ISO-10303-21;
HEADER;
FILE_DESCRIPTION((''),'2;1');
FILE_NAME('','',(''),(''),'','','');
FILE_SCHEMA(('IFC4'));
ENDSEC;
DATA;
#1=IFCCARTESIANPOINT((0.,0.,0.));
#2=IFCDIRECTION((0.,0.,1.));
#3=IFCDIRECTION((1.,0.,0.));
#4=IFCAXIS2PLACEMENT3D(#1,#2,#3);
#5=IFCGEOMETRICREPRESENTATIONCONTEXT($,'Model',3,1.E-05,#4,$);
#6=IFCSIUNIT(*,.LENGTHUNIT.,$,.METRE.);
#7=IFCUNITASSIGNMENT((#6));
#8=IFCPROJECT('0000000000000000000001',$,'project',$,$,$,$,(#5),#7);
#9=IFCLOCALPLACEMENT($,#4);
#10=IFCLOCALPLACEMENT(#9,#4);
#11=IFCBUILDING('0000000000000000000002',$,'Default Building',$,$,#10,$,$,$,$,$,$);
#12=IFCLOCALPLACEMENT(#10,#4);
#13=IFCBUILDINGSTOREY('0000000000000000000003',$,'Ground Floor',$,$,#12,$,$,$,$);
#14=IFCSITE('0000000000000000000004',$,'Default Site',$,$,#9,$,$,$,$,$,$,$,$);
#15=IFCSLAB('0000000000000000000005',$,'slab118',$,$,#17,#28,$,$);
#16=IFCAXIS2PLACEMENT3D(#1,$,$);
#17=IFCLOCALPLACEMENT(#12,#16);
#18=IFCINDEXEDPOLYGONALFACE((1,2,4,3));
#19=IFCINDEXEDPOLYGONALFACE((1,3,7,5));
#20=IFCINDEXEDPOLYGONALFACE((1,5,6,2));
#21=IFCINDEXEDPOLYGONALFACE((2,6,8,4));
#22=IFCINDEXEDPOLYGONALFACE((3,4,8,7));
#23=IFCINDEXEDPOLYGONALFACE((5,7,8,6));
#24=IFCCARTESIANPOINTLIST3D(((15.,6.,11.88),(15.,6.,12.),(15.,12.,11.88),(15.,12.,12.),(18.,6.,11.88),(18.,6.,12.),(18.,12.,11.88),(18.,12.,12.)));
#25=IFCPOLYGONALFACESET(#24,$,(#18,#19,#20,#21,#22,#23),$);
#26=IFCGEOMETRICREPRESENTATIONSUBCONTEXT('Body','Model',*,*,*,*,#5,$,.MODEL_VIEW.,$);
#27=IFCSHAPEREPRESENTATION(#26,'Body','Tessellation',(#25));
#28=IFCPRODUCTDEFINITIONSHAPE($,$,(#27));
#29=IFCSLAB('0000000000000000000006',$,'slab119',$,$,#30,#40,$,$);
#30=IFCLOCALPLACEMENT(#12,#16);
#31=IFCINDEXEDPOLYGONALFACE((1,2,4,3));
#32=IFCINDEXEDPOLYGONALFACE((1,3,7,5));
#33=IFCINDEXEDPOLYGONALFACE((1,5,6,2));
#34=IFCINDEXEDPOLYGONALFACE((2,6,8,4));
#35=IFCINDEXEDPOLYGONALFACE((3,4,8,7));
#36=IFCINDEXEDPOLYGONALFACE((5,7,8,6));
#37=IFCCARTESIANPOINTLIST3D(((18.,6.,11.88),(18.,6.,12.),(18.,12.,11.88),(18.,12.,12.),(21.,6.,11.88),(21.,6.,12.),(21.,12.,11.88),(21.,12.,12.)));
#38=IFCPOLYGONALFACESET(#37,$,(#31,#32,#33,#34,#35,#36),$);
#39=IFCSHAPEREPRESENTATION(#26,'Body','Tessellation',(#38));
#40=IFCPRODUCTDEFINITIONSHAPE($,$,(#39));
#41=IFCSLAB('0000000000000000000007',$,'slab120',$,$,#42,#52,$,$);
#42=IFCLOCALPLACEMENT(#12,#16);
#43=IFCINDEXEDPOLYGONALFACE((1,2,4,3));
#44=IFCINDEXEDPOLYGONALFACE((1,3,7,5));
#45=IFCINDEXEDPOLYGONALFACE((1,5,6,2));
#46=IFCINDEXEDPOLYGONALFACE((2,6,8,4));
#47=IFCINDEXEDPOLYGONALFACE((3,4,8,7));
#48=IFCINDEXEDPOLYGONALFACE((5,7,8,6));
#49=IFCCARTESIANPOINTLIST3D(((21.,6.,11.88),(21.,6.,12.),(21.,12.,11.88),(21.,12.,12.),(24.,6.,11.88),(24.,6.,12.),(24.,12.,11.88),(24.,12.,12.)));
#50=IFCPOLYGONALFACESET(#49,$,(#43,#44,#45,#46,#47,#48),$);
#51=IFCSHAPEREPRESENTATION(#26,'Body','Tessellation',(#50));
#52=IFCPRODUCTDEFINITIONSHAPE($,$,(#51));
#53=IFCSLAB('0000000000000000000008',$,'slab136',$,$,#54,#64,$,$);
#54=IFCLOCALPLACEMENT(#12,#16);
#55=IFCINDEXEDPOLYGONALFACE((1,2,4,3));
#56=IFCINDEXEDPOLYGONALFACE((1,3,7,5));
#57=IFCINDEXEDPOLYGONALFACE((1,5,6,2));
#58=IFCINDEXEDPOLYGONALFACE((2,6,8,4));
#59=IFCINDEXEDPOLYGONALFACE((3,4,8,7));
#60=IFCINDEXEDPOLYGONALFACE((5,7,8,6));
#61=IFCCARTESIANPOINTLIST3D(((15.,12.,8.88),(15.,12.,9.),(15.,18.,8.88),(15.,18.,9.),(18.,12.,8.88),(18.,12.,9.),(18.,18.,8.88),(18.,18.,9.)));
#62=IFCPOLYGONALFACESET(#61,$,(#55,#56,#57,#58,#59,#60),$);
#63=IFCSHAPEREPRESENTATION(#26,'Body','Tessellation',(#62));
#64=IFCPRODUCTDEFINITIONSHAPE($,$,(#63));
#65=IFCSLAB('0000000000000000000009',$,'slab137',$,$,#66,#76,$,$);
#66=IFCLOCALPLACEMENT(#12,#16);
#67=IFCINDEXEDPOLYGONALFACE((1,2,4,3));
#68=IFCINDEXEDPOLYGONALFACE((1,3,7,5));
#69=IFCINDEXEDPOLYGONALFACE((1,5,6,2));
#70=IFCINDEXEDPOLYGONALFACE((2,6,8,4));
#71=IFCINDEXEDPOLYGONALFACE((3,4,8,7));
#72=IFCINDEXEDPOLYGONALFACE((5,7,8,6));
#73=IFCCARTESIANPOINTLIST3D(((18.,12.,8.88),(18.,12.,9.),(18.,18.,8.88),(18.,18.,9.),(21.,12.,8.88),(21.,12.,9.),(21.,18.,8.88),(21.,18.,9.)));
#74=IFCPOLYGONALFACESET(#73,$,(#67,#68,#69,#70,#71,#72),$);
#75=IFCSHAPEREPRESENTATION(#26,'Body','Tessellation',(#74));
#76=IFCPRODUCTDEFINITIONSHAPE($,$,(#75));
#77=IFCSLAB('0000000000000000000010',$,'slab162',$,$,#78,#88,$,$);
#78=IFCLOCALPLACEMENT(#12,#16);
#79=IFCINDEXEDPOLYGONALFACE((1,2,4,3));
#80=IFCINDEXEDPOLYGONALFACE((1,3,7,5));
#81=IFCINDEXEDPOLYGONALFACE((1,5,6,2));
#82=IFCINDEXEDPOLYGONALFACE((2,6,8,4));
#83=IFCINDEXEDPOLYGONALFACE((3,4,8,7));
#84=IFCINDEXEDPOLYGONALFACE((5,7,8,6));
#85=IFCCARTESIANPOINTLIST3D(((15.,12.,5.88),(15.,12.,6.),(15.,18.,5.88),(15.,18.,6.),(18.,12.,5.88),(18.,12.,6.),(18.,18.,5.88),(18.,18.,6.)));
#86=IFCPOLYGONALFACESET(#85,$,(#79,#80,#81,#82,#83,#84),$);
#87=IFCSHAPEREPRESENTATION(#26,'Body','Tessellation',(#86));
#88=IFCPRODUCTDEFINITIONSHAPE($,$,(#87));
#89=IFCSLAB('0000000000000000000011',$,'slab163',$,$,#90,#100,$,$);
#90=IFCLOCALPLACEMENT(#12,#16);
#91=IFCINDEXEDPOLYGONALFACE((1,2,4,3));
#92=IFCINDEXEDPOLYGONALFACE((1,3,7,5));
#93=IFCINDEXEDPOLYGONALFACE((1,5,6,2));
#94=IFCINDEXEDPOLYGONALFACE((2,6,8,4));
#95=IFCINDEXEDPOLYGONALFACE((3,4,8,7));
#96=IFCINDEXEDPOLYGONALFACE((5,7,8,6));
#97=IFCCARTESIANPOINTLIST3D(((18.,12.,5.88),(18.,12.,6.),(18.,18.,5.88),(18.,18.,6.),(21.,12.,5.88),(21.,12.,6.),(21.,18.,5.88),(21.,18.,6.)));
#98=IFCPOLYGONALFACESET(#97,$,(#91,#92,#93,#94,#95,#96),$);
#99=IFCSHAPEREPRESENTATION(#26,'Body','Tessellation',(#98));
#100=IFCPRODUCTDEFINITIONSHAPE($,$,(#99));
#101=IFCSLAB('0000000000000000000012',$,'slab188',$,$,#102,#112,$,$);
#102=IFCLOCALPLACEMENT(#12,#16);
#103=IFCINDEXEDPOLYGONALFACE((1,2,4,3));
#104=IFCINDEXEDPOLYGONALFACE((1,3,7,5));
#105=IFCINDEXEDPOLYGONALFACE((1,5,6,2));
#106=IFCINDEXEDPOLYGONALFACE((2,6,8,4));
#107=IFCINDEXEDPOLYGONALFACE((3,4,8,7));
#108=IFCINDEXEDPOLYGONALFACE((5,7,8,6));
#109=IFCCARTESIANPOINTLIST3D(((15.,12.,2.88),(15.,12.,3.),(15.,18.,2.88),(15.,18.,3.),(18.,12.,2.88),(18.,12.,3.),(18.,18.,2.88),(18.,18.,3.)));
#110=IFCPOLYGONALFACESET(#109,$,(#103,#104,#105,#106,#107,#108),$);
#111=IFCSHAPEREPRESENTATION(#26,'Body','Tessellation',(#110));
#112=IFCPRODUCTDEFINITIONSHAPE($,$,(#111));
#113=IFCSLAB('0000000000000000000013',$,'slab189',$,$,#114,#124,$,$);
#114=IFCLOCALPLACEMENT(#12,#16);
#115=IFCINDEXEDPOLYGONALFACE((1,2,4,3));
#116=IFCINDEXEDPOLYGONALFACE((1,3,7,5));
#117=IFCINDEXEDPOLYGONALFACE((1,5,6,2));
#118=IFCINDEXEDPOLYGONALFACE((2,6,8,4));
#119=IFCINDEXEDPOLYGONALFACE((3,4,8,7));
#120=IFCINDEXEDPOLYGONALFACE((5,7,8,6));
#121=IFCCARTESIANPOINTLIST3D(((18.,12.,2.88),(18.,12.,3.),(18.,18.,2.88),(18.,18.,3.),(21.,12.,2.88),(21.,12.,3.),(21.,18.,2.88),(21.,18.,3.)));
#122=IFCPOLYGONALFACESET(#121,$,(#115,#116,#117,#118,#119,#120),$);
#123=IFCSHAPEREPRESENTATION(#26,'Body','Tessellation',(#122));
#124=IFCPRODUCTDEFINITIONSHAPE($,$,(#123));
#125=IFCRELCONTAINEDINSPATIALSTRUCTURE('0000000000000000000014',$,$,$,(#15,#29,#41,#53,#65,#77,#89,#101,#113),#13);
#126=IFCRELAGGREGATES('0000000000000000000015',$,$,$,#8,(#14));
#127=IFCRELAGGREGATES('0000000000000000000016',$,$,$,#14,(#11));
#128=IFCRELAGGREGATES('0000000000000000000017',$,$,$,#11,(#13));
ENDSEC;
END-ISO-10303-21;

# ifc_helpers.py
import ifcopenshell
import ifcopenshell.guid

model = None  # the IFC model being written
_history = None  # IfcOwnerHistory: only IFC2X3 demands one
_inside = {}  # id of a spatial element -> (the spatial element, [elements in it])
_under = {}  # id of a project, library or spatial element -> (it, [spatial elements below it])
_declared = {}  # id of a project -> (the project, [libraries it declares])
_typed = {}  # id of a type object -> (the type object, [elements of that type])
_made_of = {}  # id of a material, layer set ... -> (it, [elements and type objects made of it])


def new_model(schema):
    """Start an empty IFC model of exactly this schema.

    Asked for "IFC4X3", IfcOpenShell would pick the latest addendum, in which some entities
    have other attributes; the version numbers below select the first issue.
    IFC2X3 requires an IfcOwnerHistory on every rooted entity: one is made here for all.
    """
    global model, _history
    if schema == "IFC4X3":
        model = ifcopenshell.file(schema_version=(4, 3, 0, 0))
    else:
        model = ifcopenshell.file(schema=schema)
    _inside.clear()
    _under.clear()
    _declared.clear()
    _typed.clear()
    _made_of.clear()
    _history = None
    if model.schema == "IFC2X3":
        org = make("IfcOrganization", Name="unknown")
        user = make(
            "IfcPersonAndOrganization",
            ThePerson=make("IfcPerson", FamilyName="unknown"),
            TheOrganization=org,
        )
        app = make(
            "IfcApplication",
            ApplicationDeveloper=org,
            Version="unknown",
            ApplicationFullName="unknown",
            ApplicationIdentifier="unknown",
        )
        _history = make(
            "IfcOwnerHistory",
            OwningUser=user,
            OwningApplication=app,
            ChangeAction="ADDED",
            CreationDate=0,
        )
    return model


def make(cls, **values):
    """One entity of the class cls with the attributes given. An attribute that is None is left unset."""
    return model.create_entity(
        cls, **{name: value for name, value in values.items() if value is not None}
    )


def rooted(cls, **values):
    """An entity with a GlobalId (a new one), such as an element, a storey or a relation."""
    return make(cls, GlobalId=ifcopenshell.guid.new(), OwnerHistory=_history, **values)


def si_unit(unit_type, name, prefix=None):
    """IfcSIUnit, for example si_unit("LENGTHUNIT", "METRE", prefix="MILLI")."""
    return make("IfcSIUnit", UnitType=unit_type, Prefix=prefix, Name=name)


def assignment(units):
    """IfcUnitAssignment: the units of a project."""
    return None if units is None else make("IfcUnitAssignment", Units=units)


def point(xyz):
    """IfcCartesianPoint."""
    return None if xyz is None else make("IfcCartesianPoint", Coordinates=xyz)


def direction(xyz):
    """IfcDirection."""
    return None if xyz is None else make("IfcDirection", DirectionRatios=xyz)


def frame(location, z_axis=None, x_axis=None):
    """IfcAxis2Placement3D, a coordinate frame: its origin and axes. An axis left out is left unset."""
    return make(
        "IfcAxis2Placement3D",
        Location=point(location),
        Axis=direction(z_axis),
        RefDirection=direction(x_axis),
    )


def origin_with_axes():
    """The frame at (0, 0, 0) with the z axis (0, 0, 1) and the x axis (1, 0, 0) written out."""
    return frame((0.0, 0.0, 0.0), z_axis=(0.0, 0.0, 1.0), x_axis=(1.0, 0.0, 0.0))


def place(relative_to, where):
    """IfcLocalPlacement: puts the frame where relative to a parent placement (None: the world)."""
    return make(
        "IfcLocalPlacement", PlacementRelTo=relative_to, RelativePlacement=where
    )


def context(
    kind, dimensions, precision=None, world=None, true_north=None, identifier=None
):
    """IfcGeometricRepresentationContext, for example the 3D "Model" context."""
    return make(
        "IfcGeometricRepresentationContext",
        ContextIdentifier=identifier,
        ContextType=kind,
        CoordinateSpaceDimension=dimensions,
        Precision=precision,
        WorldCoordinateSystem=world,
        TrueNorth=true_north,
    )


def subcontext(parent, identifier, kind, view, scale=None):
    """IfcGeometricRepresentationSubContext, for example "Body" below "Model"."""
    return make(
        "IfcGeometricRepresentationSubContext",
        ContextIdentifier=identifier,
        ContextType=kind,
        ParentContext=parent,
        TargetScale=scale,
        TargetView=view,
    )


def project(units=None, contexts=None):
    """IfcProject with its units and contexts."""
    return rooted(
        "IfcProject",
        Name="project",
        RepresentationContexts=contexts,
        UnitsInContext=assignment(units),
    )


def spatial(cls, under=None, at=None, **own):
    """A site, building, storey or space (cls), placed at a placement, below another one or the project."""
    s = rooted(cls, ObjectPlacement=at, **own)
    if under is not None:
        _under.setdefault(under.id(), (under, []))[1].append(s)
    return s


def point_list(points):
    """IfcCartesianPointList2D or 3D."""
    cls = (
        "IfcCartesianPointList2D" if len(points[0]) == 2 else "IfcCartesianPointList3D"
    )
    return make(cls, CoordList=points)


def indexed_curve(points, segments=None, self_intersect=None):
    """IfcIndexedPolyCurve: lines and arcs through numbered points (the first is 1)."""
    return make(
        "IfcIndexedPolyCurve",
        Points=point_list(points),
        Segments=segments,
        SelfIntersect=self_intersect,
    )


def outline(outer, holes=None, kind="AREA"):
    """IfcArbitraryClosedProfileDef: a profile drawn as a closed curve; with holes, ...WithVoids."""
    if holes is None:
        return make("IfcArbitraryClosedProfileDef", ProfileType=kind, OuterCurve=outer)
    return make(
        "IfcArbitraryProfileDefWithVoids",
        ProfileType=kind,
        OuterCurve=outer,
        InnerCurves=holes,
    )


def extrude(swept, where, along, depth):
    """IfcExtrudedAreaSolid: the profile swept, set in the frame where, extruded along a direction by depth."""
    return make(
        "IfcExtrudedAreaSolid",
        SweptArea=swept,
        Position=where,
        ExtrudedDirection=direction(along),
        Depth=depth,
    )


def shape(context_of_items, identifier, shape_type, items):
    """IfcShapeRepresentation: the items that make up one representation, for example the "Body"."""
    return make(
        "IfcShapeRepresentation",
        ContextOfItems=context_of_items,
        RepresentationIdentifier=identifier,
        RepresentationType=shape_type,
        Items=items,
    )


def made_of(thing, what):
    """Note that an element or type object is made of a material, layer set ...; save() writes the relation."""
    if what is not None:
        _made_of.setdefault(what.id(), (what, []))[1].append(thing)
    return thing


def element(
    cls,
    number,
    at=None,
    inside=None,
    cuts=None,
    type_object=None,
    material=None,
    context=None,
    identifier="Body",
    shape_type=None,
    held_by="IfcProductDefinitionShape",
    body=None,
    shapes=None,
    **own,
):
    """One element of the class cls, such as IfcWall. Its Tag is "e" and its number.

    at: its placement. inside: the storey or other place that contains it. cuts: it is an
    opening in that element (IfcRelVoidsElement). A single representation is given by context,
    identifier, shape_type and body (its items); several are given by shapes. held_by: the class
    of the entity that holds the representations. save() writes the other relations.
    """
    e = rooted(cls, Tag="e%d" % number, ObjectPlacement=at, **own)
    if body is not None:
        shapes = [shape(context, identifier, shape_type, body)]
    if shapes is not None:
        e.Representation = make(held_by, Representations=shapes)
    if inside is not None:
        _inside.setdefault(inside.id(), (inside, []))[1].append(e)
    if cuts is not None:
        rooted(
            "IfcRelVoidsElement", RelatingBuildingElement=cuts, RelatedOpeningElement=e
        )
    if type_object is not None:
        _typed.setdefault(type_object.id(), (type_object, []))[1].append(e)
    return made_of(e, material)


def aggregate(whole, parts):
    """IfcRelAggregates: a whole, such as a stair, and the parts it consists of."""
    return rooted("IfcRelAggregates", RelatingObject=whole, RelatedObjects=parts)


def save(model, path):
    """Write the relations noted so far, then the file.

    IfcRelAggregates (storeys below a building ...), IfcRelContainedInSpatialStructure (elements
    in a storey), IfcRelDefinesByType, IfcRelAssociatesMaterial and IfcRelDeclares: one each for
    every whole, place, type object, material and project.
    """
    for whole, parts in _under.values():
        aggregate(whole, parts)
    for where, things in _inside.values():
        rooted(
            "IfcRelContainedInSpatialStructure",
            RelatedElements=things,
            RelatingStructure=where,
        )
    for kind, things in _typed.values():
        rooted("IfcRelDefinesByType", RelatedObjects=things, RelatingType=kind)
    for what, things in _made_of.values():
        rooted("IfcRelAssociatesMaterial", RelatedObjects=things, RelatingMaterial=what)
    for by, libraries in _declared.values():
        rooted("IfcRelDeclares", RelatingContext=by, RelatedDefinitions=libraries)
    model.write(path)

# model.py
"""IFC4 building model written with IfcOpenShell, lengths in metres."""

from ifc_helpers import new_model, si_unit, frame, origin_with_axes, place, context, subcontext, project, spatial, indexed_curve, outline, extrude, element, save


model = new_model("IFC4")

# Units and contexts
model_context = context("Model", 3, precision=1e-05, world=origin_with_axes())
body_context = subcontext(model_context, "Body", "Model", "MODEL_VIEW")
ifc_project = project(units=[si_unit("LENGTHUNIT", "METRE")], contexts=[model_context])

# Site, building, storey
site_placement = place(None, origin_with_axes())
site = spatial("IfcSite", under=ifc_project, at=site_placement, Name="Default Site")
building_placement = place(site_placement, origin_with_axes())
building = spatial("IfcBuilding", under=site, at=building_placement, Name="Default Building")
storey_placement = place(building_placement, origin_with_axes())
storey = spatial("IfcBuildingStorey", under=building, at=storey_placement, Name="Ground Floor")

# Slabs
for number, where, z_axis, x_axis, name in (
    (1, (15.0, 6.0, 11.88), (0.0, 0.0, 1.0), (1.0, 0.0, 0.0), "slab118"),
    (2, (18.0, 6.0, 11.88), (0.0, 0.0, 1.0), (1.0, 0.0, 0.0), "slab119"),
    (3, (21.0, 6.0, 11.88), (0.0, 0.0, 1.0), (1.0, 0.0, 0.0), "slab120"),
    (4, (15.0, 12.0, 8.88), (0.0, 0.0, 1.0), (1.0, 0.0, 0.0), "slab136"),
    (5, (18.0, 12.0, 8.88), (0.0, 0.0, 1.0), (1.0, 0.0, 0.0), "slab137"),
    (6, (15.0, 12.0, 5.88), (0.0, 0.0, 1.0), (1.0, 0.0, 0.0), "slab162"),
    (7, (18.0, 12.0, 5.88), (0.0, 0.0, 1.0), (1.0, 0.0, 0.0), "slab163"),
    (8, (15.0, 12.0, 2.88), (0.0, 0.0, 1.0), (1.0, 0.0, 0.0), "slab188"),
    (9, (18.0, 12.0, 2.88), (0.0, 0.0, 1.0), (1.0, 0.0, 0.0), "slab189"),
):
    element("IfcSlab", number, at=place(storey_placement, frame(where, z_axis=z_axis, x_axis=x_axis)), inside=storey, Name=name, context=body_context, shape_type="SweptSolid", body=[
        extrude(outline(indexed_curve([(0.0, 0.0), (0.0, 6.0), (3.0, 6.0), (3.0, 0.0), (0.0, 0.0)], self_intersect=False)), origin_with_axes(), (0.0, 0.0, 1.0), 0.12),
    ])

save(model, "model.ifc")
